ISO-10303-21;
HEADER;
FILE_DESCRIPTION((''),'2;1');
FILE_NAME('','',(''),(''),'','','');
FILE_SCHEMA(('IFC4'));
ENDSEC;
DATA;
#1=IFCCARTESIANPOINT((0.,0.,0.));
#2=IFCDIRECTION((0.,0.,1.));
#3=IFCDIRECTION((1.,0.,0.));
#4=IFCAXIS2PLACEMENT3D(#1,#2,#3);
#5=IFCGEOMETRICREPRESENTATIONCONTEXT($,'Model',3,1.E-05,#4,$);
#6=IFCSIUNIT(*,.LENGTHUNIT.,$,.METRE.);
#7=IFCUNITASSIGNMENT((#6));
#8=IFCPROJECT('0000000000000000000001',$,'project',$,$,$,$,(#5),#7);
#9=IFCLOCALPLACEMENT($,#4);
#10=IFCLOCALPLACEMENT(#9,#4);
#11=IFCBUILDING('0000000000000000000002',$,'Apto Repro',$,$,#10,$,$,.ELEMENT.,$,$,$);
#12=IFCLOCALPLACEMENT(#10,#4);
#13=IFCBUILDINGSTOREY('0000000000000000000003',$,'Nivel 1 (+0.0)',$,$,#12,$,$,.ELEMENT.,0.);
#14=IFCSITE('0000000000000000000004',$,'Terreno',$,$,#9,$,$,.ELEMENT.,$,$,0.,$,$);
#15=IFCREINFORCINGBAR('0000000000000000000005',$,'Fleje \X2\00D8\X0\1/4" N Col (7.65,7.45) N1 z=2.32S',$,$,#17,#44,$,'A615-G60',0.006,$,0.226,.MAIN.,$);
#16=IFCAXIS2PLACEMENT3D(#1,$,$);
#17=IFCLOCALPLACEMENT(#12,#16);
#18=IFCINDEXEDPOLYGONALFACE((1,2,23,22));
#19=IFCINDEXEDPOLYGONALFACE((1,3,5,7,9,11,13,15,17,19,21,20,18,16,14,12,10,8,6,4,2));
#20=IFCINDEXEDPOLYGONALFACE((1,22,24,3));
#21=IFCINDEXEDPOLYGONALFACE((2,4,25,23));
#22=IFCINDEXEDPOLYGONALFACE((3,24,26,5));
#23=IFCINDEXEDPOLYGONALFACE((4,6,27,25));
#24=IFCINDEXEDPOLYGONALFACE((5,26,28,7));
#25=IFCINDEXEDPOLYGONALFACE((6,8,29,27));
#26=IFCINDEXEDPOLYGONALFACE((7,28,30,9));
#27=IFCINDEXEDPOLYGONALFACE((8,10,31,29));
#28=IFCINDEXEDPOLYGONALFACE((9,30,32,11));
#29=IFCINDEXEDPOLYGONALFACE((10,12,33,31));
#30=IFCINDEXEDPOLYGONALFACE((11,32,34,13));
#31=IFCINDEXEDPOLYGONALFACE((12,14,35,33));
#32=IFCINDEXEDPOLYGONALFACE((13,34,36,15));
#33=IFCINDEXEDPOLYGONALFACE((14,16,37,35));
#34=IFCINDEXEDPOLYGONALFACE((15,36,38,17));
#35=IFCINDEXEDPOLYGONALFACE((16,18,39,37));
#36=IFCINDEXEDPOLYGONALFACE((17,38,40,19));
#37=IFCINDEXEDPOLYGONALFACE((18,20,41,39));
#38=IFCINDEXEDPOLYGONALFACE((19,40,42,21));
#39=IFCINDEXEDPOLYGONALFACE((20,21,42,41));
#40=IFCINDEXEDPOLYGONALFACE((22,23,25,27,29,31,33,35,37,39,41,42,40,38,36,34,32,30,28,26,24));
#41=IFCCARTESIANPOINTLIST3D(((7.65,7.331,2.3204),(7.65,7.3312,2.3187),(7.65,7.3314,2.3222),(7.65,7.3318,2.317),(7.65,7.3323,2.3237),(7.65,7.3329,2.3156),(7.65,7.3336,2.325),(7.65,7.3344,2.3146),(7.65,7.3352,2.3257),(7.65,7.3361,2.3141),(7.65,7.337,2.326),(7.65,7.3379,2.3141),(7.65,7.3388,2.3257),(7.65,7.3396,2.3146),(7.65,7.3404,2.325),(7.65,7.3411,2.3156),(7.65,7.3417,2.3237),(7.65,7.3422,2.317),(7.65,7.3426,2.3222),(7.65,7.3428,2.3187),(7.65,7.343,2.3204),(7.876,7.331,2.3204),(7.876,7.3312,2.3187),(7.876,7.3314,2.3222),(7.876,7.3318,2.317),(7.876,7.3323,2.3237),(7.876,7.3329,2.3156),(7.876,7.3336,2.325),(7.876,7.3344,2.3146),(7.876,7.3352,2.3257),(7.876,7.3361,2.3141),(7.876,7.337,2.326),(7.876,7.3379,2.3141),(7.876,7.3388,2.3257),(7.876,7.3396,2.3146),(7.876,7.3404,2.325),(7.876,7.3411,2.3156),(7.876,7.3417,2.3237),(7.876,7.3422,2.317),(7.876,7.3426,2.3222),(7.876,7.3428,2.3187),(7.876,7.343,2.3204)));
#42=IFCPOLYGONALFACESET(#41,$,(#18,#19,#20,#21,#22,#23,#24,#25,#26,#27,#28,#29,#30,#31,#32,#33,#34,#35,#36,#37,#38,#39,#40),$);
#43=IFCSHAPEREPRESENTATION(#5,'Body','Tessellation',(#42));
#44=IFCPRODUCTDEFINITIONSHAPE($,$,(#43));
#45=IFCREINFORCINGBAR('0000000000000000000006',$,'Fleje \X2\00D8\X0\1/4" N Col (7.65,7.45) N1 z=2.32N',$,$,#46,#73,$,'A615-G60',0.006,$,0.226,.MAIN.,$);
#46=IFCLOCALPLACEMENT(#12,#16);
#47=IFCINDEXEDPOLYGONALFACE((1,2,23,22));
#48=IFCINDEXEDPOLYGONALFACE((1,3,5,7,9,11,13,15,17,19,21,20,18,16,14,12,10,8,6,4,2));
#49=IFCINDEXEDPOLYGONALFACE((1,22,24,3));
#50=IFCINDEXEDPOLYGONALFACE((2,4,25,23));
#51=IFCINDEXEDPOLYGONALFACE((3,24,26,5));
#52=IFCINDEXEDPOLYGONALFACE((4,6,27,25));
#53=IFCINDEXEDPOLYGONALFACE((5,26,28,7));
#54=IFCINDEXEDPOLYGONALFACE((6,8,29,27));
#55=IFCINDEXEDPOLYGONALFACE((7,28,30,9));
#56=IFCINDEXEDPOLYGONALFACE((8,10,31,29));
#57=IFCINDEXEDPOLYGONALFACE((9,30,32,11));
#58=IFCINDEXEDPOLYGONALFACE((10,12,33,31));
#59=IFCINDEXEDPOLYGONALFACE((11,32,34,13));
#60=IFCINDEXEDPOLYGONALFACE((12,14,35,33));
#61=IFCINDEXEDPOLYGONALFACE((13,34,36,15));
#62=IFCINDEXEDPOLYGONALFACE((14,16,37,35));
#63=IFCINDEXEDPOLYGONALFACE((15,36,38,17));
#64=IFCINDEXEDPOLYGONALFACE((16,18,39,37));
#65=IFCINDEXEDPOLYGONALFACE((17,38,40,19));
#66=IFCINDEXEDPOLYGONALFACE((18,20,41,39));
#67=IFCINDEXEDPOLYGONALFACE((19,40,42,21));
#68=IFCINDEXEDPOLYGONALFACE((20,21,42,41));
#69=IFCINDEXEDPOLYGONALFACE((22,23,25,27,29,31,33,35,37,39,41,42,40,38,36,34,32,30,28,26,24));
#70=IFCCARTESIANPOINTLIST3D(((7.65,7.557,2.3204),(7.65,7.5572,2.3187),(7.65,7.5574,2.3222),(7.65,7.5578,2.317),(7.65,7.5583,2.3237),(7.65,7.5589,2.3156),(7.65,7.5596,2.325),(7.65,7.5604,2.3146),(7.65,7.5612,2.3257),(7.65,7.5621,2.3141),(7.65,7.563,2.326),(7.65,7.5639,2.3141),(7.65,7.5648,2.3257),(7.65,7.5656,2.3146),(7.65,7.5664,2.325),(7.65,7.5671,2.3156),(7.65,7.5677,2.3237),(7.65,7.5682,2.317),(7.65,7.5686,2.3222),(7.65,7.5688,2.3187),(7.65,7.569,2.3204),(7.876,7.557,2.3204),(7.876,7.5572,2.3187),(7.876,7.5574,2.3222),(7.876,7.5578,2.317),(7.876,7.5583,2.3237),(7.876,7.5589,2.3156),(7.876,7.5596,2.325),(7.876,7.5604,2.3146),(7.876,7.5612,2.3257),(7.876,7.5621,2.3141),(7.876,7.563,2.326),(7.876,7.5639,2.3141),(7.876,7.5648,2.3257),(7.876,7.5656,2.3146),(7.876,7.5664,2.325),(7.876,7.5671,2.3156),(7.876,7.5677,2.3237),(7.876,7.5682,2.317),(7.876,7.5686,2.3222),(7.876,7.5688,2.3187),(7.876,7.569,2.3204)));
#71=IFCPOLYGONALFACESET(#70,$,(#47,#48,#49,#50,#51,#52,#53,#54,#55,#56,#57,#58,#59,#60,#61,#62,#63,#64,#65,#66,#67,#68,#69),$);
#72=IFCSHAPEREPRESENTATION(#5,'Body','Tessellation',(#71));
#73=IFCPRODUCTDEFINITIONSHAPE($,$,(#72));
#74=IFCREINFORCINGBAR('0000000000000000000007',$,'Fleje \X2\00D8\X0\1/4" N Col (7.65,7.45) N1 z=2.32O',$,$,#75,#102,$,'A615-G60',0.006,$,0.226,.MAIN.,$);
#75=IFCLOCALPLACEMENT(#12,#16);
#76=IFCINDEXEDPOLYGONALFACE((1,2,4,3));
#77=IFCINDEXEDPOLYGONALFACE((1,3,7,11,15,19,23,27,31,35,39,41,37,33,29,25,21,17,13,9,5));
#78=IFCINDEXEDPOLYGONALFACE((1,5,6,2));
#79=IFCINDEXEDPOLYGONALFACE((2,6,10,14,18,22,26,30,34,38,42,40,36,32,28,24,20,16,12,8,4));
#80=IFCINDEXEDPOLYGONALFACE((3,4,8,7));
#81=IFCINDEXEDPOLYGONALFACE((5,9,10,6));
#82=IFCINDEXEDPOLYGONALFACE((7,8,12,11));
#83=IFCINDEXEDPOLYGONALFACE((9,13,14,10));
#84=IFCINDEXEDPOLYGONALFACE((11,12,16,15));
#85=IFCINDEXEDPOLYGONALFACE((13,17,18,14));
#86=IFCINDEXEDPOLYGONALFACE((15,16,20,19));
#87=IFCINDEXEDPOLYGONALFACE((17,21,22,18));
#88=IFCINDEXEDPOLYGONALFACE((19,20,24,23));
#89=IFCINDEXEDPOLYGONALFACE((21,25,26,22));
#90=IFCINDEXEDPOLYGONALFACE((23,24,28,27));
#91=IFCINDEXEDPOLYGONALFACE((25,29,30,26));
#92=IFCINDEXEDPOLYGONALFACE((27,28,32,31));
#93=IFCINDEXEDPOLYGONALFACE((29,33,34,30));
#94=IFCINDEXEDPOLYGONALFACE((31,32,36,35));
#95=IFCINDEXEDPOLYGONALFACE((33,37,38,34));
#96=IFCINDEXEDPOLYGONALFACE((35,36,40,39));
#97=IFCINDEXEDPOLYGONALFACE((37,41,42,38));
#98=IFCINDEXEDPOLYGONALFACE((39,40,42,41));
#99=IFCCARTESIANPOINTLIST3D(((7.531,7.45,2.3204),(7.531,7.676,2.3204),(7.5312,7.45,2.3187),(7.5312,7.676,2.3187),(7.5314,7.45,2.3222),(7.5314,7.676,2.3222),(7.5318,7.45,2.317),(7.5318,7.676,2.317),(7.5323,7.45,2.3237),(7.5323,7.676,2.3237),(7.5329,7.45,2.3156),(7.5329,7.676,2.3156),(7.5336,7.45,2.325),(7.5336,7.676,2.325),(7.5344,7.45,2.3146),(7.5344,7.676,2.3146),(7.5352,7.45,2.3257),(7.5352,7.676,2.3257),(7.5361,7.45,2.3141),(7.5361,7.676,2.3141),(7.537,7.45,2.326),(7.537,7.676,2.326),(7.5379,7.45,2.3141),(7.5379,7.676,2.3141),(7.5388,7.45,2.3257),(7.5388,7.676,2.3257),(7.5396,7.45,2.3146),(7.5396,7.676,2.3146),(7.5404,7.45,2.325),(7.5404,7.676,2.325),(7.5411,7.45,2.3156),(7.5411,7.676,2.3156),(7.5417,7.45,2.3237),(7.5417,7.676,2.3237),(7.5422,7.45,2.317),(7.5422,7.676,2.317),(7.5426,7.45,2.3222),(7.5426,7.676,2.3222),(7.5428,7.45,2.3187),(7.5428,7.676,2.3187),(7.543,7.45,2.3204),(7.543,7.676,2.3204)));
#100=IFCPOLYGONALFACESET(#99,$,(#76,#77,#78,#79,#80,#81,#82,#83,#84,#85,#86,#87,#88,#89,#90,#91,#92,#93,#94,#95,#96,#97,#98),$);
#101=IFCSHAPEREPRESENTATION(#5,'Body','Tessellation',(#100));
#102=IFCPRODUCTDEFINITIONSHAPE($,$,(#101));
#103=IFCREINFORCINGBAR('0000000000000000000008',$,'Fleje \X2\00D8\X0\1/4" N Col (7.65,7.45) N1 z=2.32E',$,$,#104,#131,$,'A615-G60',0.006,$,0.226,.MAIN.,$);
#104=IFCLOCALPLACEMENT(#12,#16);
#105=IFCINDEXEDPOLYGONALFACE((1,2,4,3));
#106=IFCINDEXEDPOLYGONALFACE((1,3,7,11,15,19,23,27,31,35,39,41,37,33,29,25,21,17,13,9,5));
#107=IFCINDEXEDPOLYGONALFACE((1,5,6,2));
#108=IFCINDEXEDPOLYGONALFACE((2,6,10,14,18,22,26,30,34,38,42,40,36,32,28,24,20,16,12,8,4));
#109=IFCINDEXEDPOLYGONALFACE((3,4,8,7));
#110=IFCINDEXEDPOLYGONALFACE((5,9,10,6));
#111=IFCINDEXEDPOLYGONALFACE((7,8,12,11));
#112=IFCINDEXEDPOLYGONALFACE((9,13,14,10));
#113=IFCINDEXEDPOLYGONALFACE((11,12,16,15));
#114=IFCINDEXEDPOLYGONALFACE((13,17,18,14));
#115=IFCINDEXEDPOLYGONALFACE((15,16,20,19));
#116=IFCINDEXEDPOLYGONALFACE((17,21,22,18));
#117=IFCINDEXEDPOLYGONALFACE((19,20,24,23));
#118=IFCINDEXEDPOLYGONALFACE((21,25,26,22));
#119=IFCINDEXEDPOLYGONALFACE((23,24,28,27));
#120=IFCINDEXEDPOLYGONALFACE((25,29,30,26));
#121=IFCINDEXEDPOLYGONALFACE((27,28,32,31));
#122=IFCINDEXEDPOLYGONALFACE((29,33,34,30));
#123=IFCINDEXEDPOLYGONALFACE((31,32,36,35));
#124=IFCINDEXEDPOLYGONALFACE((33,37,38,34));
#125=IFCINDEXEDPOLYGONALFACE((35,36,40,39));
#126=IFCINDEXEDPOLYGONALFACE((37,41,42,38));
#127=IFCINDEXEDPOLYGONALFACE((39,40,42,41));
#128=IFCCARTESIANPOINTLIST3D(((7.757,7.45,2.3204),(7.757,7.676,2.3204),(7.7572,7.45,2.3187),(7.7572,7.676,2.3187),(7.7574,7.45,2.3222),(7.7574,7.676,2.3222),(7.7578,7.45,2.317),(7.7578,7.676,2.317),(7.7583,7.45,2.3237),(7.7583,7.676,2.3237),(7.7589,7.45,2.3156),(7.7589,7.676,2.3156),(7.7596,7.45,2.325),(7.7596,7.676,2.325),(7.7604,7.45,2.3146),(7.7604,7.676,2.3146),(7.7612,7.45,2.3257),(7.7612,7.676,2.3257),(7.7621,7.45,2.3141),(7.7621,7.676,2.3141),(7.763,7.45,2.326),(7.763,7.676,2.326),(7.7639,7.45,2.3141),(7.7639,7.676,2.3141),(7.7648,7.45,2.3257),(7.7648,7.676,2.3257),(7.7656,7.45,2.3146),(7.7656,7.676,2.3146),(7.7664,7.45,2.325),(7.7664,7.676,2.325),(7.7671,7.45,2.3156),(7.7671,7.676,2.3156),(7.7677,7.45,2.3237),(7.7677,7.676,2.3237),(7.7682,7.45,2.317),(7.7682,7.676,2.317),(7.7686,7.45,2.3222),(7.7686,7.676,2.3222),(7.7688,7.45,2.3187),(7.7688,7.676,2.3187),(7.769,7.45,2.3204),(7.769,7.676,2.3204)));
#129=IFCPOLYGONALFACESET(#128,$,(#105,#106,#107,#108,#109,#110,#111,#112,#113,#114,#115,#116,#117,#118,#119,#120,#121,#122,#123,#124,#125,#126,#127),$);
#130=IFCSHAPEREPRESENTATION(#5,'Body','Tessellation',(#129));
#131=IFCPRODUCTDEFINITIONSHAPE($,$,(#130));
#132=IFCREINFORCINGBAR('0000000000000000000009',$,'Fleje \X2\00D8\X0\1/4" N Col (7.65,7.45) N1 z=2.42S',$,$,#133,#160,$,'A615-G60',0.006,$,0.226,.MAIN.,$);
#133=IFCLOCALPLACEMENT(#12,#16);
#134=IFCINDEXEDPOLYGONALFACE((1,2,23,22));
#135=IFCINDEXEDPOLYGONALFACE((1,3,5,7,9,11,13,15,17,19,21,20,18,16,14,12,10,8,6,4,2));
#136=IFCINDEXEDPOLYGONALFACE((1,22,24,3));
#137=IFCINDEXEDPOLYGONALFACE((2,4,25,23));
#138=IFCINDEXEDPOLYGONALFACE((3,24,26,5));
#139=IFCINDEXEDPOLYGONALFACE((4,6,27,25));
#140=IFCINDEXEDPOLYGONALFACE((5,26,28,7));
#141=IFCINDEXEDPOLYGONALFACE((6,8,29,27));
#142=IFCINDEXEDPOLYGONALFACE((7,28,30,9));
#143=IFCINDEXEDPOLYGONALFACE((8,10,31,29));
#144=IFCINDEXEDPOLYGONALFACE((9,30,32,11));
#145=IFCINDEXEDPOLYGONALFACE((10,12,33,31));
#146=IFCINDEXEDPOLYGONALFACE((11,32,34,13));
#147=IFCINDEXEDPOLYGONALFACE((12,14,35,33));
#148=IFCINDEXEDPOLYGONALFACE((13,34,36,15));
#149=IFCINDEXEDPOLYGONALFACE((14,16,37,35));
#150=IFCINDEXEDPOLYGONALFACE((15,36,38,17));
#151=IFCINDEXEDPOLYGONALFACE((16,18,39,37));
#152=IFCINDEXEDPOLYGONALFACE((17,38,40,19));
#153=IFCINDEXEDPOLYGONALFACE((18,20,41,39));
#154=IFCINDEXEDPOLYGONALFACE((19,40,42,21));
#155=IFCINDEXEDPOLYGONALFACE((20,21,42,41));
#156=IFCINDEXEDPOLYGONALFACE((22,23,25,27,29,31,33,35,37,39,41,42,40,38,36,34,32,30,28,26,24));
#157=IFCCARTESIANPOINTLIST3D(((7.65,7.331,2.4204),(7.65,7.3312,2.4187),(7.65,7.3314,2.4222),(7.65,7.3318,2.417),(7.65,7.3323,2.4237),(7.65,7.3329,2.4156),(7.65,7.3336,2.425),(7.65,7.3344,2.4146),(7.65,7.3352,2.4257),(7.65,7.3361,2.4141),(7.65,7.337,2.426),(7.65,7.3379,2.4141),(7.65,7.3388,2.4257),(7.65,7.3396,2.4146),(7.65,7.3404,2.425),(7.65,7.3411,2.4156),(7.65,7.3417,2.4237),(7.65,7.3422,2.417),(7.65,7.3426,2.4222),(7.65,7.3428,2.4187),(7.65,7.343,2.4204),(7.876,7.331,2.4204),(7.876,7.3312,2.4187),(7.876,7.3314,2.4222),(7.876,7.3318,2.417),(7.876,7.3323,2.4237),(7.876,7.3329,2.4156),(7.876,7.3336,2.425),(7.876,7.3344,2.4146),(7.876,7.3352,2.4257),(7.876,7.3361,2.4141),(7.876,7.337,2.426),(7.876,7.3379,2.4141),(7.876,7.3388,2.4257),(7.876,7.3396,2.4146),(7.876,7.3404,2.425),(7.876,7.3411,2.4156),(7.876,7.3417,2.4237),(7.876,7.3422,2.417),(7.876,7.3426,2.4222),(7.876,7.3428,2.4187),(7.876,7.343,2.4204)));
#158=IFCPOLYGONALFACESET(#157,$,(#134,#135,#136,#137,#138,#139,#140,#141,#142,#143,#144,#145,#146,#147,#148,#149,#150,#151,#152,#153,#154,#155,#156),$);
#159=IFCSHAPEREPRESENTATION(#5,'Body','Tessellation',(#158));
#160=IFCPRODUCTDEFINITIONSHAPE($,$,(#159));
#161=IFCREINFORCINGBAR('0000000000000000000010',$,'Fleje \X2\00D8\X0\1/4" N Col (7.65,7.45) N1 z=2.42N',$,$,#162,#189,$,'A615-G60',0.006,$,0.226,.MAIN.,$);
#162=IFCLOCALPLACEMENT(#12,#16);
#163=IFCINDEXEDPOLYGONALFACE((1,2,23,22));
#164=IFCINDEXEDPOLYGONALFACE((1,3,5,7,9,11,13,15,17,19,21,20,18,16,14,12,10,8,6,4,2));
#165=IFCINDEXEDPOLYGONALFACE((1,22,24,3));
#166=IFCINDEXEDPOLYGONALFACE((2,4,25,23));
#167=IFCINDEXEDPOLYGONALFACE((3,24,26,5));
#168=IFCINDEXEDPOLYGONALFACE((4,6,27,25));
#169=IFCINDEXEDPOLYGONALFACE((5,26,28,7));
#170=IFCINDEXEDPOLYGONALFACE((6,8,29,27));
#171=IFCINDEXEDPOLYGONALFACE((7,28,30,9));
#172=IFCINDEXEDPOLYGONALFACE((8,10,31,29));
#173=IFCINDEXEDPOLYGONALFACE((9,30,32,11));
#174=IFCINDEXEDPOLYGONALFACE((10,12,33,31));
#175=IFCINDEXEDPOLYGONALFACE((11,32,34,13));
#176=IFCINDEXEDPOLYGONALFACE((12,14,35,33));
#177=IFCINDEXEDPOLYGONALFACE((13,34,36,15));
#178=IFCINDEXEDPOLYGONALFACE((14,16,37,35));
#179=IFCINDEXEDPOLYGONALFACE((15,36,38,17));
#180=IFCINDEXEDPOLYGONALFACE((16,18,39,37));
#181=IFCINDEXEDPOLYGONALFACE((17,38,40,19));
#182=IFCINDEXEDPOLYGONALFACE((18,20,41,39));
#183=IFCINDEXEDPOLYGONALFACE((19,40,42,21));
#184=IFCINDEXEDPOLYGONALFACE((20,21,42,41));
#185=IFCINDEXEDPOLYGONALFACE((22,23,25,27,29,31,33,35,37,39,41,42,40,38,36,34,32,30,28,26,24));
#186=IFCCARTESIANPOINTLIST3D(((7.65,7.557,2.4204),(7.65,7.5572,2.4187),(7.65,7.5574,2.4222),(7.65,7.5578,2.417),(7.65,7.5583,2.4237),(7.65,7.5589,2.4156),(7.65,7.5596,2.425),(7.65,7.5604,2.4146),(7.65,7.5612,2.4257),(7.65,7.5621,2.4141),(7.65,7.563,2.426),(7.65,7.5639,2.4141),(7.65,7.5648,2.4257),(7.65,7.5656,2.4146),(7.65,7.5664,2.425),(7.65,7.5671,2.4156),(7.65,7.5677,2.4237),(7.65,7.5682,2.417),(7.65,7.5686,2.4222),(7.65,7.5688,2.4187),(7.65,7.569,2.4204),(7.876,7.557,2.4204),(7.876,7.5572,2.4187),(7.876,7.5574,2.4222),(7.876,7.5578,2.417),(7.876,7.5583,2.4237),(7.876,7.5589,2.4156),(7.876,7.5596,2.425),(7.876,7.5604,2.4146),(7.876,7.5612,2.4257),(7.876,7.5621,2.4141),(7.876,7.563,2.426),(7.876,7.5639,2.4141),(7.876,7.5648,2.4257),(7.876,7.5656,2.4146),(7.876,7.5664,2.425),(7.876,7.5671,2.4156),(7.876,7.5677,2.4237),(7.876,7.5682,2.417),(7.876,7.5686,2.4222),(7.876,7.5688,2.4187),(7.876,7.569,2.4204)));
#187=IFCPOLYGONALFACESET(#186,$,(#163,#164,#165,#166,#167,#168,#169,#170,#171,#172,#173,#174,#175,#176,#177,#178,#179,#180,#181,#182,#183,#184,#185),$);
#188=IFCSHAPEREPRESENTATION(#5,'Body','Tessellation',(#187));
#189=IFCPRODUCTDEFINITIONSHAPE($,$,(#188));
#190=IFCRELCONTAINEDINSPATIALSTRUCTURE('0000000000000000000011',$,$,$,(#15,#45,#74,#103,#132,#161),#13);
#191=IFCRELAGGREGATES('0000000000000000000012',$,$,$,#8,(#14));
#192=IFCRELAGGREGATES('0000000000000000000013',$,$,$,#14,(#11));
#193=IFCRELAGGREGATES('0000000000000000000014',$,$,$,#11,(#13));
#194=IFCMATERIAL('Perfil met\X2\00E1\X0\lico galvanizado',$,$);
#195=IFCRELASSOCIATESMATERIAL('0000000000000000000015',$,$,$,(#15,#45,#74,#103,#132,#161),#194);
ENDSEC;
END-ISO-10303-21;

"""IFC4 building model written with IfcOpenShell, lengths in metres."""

from ifc_helpers import new_model, si_unit, frame, origin_with_axes, origin_2d_with_axis, place, context, project, spatial, circle, extrude, material, element, save


model = new_model("IFC4")

# Units and contexts
model_context = context("Model", 3, precision=1e-05, world=origin_with_axes())
ifc_project = project(units=[si_unit("LENGTHUNIT", "METRE")], contexts=[model_context])

# Site, building, storey
site_placement = place(None, origin_with_axes())
site = spatial("IfcSite", under=ifc_project, at=site_placement, Name="Terreno", CompositionType="ELEMENT", RefElevation=0.0)
building_placement = place(site_placement, origin_with_axes())
building = spatial("IfcBuilding", under=site, at=building_placement, Name="Apto Repro", CompositionType="ELEMENT")
storey_placement = place(building_placement, origin_with_axes())
storey = spatial("IfcBuildingStorey", under=building, at=storey_placement, Name="Nivel 1 (+0.0)", CompositionType="ELEMENT", Elevation=0.0)

# Reinforcing bars
ifc_material = material(Name="Perfil metálico galvanizado")
reinforcing_bar_1_placement = place(storey_placement, origin_with_axes())
element("IfcReinforcingBar", 1, at=reinforcing_bar_1_placement, inside=storey, material=ifc_material, Name="Fleje Ø1/4\" N Col (7.65,7.45) N1 z=2.32S", SteelGrade="A615-G60", BarLength=0.226, NominalDiameter=0.006, PredefinedType="MAIN", context=model_context, shape_type="SweptSolid", body=[
    extrude(circle(Radius=0.006, at=origin_2d_with_axis()), frame((7.65, 7.337, 2.32), z_axis=(1.0, 0.0, 0.0), x_axis=(0.0, 0.0, 1.0)), (0.0, 0.0, 1.0), 0.226),
])
reinforcing_bar_2_placement = place(storey_placement, origin_with_axes())
element("IfcReinforcingBar", 2, at=reinforcing_bar_2_placement, inside=storey, material=ifc_material, Name="Fleje Ø1/4\" N Col (7.65,7.45) N1 z=2.32N", SteelGrade="A615-G60", BarLength=0.226, NominalDiameter=0.006, PredefinedType="MAIN", context=model_context, shape_type="SweptSolid", body=[
    extrude(circle(Radius=0.006, at=origin_2d_with_axis()), frame((7.65, 7.563, 2.32), z_axis=(1.0, 0.0, 0.0), x_axis=(0.0, 0.0, 1.0)), (0.0, 0.0, 1.0), 0.226),
])
reinforcing_bar_3_placement = place(storey_placement, origin_with_axes())
element("IfcReinforcingBar", 3, at=reinforcing_bar_3_placement, inside=storey, material=ifc_material, Name="Fleje Ø1/4\" N Col (7.65,7.45) N1 z=2.32O", SteelGrade="A615-G60", BarLength=0.226, NominalDiameter=0.006, PredefinedType="MAIN", context=model_context, shape_type="SweptSolid", body=[
    extrude(circle(Radius=0.006, at=origin_2d_with_axis()), frame((7.537, 7.45, 2.32), z_axis=(0.0, 1.0, 0.0), x_axis=(0.0, 0.0, 1.0)), (0.0, 0.0, 1.0), 0.226),
])
reinforcing_bar_4_placement = place(storey_placement, origin_with_axes())
element("IfcReinforcingBar", 4, at=reinforcing_bar_4_placement, inside=storey, material=ifc_material, Name="Fleje Ø1/4\" N Col (7.65,7.45) N1 z=2.32E", SteelGrade="A615-G60", BarLength=0.226, NominalDiameter=0.006, PredefinedType="MAIN", context=model_context, shape_type="SweptSolid", body=[
    extrude(circle(Radius=0.006, at=origin_2d_with_axis()), frame((7.763, 7.45, 2.32), z_axis=(0.0, 1.0, 0.0), x_axis=(0.0, 0.0, 1.0)), (0.0, 0.0, 1.0), 0.226),
])
reinforcing_bar_5_placement = place(storey_placement, origin_with_axes())
element("IfcReinforcingBar", 5, at=reinforcing_bar_5_placement, inside=storey, material=ifc_material, Name="Fleje Ø1/4\" N Col (7.65,7.45) N1 z=2.42S", SteelGrade="A615-G60", BarLength=0.226, NominalDiameter=0.006, PredefinedType="MAIN", context=model_context, shape_type="SweptSolid", body=[
    extrude(circle(Radius=0.006, at=origin_2d_with_axis()), frame((7.65, 7.337, 2.42), z_axis=(1.0, 0.0, 0.0), x_axis=(0.0, 0.0, 1.0)), (0.0, 0.0, 1.0), 0.226),
])
reinforcing_bar_6_placement = place(storey_placement, origin_with_axes())
element("IfcReinforcingBar", 6, at=reinforcing_bar_6_placement, inside=storey, material=ifc_material, Name="Fleje Ø1/4\" N Col (7.65,7.45) N1 z=2.42N", SteelGrade="A615-G60", BarLength=0.226, NominalDiameter=0.006, PredefinedType="MAIN", context=model_context, shape_type="SweptSolid", body=[
    extrude(circle(Radius=0.006, at=origin_2d_with_axis()), frame((7.65, 7.563, 2.42), z_axis=(1.0, 0.0, 0.0), x_axis=(0.0, 0.0, 1.0)), (0.0, 0.0, 1.0), 0.226),
])

save(model, "model.ifc")
